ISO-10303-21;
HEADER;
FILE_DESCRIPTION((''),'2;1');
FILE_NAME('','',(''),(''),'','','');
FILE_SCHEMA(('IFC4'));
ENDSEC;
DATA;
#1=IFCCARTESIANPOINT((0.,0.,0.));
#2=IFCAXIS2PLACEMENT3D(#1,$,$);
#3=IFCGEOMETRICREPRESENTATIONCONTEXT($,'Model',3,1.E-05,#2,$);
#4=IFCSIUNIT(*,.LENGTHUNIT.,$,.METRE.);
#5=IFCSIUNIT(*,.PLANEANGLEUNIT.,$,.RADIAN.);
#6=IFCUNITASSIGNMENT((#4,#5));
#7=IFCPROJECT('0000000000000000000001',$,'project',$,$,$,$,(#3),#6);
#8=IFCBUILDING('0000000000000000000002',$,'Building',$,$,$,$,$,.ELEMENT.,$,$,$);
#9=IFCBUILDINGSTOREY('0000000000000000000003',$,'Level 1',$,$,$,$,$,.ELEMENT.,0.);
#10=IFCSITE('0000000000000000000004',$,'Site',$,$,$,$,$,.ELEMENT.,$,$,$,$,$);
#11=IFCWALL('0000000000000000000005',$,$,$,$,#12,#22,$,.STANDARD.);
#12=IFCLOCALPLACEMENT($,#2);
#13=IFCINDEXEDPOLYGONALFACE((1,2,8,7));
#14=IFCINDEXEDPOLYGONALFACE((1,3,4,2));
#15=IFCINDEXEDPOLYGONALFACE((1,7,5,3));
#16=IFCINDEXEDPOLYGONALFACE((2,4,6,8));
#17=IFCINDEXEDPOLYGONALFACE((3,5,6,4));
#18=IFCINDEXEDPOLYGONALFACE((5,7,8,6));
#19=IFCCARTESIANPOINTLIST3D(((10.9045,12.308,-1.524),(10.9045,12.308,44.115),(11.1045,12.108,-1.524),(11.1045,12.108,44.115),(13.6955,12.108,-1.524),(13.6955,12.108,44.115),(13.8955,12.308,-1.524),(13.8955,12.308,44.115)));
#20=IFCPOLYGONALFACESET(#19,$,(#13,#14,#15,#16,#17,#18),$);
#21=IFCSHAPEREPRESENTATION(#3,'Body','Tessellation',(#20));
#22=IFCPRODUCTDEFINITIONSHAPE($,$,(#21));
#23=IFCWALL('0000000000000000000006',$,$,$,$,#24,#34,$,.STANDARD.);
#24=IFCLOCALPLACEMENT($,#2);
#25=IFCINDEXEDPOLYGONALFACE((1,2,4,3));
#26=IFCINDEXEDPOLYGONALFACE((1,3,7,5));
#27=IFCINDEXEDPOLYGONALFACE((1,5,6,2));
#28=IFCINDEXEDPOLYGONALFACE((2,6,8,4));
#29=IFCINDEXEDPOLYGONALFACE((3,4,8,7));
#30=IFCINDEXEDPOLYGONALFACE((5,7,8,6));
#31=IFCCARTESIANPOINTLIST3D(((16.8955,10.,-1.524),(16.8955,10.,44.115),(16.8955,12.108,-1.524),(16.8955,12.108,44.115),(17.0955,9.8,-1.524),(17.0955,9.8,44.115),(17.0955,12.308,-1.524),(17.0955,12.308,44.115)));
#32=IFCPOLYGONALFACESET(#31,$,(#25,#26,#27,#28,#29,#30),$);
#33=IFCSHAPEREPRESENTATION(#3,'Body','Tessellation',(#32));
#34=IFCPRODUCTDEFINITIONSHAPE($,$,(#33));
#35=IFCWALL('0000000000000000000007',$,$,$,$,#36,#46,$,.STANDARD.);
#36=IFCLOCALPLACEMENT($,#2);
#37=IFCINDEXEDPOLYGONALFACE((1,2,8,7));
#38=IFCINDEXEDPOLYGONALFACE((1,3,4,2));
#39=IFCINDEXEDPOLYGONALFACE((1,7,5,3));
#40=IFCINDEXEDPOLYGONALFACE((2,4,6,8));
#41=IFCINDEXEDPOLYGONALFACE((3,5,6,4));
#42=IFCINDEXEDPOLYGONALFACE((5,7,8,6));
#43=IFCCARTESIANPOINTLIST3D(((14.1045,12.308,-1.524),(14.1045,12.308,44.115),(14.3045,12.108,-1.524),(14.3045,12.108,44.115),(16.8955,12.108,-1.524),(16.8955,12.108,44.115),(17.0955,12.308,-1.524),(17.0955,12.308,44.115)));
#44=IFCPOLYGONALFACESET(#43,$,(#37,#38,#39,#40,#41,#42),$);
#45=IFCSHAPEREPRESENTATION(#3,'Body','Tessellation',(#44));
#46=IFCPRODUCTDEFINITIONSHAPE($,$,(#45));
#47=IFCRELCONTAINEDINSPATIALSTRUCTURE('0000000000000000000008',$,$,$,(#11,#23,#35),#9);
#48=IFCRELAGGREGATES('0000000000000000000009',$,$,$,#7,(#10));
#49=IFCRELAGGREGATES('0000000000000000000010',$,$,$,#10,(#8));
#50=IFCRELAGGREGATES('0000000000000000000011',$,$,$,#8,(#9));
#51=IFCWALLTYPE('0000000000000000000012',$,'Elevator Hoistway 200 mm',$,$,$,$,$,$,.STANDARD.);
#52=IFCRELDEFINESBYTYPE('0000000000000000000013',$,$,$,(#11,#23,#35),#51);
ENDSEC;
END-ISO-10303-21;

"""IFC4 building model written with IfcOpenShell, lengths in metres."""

from ifc_helpers import new_model, si_unit, frame, origin, place, context, project, spatial, polyline, outline, extrude, type_object, element, save


model = new_model("IFC4")

# Units and contexts
model_context = context("Model", 3, precision=1e-05, world=origin())
ifc_project = project(units=[si_unit("LENGTHUNIT", "METRE"), si_unit("PLANEANGLEUNIT", "RADIAN")], contexts=[model_context])

# Site, building, storey
site = spatial("IfcSite", under=ifc_project, Name="Site", CompositionType="ELEMENT")
building = spatial("IfcBuilding", under=site, Name="Building", CompositionType="ELEMENT")
storey = spatial("IfcBuildingStorey", under=building, Name="Level 1", CompositionType="ELEMENT", Elevation=0.0)

# Wall
wall_type = type_object("IfcWallType", Name="Elevator Hoistway 200 mm", PredefinedType="STANDARD")
wall_1_placement = place(None, frame((13.7955, 12.208, -1.524), z_axis=(0.0, 0.0, 1.0), x_axis=(-1.0, 0.0, 0.0)))
element("IfcWall", 1, at=wall_1_placement, inside=storey, type_object=wall_type, PredefinedType="STANDARD", context=model_context, shape_type="SweptSolid", body=[
    extrude(outline(polyline([(-0.1, -0.1), (2.891, -0.1), (2.691, 0.1), (0.1, 0.1), (-0.1, -0.1)])), origin(), (0.0, 0.0, 1.0), 45.639),
])

# Walls
wall_2_placement = place(None, frame((16.9955, 9.9, -1.524), z_axis=(0.0, 0.0, 1.0), x_axis=(0.0, 1.0, 0.0)))
element("IfcWall", 2, at=wall_2_placement, inside=storey, type_object=wall_type, PredefinedType="STANDARD", context=model_context, shape_type="SweptSolid", body=[
    extrude(outline(polyline([(-0.1, -0.1), (2.408, -0.1), (2.208, 0.1), (0.1, 0.1), (-0.1, -0.1)])), origin(), (0.0, 0.0, 1.0), 45.639),
])
wall_3_placement = place(None, frame((16.9955, 12.208, -1.524), z_axis=(0.0, 0.0, 1.0), x_axis=(-1.0, 0.0, 0.0)))
element("IfcWall", 3, at=wall_3_placement, inside=storey, type_object=wall_type, PredefinedType="STANDARD", context=model_context, shape_type="SweptSolid", body=[
    extrude(outline(polyline([(-0.1, -0.1), (2.891, -0.1), (2.691, 0.1), (0.1, 0.1), (-0.1, -0.1)])), origin(), (0.0, 0.0, 1.0), 45.639),
])

save(model, "model.ifc")
